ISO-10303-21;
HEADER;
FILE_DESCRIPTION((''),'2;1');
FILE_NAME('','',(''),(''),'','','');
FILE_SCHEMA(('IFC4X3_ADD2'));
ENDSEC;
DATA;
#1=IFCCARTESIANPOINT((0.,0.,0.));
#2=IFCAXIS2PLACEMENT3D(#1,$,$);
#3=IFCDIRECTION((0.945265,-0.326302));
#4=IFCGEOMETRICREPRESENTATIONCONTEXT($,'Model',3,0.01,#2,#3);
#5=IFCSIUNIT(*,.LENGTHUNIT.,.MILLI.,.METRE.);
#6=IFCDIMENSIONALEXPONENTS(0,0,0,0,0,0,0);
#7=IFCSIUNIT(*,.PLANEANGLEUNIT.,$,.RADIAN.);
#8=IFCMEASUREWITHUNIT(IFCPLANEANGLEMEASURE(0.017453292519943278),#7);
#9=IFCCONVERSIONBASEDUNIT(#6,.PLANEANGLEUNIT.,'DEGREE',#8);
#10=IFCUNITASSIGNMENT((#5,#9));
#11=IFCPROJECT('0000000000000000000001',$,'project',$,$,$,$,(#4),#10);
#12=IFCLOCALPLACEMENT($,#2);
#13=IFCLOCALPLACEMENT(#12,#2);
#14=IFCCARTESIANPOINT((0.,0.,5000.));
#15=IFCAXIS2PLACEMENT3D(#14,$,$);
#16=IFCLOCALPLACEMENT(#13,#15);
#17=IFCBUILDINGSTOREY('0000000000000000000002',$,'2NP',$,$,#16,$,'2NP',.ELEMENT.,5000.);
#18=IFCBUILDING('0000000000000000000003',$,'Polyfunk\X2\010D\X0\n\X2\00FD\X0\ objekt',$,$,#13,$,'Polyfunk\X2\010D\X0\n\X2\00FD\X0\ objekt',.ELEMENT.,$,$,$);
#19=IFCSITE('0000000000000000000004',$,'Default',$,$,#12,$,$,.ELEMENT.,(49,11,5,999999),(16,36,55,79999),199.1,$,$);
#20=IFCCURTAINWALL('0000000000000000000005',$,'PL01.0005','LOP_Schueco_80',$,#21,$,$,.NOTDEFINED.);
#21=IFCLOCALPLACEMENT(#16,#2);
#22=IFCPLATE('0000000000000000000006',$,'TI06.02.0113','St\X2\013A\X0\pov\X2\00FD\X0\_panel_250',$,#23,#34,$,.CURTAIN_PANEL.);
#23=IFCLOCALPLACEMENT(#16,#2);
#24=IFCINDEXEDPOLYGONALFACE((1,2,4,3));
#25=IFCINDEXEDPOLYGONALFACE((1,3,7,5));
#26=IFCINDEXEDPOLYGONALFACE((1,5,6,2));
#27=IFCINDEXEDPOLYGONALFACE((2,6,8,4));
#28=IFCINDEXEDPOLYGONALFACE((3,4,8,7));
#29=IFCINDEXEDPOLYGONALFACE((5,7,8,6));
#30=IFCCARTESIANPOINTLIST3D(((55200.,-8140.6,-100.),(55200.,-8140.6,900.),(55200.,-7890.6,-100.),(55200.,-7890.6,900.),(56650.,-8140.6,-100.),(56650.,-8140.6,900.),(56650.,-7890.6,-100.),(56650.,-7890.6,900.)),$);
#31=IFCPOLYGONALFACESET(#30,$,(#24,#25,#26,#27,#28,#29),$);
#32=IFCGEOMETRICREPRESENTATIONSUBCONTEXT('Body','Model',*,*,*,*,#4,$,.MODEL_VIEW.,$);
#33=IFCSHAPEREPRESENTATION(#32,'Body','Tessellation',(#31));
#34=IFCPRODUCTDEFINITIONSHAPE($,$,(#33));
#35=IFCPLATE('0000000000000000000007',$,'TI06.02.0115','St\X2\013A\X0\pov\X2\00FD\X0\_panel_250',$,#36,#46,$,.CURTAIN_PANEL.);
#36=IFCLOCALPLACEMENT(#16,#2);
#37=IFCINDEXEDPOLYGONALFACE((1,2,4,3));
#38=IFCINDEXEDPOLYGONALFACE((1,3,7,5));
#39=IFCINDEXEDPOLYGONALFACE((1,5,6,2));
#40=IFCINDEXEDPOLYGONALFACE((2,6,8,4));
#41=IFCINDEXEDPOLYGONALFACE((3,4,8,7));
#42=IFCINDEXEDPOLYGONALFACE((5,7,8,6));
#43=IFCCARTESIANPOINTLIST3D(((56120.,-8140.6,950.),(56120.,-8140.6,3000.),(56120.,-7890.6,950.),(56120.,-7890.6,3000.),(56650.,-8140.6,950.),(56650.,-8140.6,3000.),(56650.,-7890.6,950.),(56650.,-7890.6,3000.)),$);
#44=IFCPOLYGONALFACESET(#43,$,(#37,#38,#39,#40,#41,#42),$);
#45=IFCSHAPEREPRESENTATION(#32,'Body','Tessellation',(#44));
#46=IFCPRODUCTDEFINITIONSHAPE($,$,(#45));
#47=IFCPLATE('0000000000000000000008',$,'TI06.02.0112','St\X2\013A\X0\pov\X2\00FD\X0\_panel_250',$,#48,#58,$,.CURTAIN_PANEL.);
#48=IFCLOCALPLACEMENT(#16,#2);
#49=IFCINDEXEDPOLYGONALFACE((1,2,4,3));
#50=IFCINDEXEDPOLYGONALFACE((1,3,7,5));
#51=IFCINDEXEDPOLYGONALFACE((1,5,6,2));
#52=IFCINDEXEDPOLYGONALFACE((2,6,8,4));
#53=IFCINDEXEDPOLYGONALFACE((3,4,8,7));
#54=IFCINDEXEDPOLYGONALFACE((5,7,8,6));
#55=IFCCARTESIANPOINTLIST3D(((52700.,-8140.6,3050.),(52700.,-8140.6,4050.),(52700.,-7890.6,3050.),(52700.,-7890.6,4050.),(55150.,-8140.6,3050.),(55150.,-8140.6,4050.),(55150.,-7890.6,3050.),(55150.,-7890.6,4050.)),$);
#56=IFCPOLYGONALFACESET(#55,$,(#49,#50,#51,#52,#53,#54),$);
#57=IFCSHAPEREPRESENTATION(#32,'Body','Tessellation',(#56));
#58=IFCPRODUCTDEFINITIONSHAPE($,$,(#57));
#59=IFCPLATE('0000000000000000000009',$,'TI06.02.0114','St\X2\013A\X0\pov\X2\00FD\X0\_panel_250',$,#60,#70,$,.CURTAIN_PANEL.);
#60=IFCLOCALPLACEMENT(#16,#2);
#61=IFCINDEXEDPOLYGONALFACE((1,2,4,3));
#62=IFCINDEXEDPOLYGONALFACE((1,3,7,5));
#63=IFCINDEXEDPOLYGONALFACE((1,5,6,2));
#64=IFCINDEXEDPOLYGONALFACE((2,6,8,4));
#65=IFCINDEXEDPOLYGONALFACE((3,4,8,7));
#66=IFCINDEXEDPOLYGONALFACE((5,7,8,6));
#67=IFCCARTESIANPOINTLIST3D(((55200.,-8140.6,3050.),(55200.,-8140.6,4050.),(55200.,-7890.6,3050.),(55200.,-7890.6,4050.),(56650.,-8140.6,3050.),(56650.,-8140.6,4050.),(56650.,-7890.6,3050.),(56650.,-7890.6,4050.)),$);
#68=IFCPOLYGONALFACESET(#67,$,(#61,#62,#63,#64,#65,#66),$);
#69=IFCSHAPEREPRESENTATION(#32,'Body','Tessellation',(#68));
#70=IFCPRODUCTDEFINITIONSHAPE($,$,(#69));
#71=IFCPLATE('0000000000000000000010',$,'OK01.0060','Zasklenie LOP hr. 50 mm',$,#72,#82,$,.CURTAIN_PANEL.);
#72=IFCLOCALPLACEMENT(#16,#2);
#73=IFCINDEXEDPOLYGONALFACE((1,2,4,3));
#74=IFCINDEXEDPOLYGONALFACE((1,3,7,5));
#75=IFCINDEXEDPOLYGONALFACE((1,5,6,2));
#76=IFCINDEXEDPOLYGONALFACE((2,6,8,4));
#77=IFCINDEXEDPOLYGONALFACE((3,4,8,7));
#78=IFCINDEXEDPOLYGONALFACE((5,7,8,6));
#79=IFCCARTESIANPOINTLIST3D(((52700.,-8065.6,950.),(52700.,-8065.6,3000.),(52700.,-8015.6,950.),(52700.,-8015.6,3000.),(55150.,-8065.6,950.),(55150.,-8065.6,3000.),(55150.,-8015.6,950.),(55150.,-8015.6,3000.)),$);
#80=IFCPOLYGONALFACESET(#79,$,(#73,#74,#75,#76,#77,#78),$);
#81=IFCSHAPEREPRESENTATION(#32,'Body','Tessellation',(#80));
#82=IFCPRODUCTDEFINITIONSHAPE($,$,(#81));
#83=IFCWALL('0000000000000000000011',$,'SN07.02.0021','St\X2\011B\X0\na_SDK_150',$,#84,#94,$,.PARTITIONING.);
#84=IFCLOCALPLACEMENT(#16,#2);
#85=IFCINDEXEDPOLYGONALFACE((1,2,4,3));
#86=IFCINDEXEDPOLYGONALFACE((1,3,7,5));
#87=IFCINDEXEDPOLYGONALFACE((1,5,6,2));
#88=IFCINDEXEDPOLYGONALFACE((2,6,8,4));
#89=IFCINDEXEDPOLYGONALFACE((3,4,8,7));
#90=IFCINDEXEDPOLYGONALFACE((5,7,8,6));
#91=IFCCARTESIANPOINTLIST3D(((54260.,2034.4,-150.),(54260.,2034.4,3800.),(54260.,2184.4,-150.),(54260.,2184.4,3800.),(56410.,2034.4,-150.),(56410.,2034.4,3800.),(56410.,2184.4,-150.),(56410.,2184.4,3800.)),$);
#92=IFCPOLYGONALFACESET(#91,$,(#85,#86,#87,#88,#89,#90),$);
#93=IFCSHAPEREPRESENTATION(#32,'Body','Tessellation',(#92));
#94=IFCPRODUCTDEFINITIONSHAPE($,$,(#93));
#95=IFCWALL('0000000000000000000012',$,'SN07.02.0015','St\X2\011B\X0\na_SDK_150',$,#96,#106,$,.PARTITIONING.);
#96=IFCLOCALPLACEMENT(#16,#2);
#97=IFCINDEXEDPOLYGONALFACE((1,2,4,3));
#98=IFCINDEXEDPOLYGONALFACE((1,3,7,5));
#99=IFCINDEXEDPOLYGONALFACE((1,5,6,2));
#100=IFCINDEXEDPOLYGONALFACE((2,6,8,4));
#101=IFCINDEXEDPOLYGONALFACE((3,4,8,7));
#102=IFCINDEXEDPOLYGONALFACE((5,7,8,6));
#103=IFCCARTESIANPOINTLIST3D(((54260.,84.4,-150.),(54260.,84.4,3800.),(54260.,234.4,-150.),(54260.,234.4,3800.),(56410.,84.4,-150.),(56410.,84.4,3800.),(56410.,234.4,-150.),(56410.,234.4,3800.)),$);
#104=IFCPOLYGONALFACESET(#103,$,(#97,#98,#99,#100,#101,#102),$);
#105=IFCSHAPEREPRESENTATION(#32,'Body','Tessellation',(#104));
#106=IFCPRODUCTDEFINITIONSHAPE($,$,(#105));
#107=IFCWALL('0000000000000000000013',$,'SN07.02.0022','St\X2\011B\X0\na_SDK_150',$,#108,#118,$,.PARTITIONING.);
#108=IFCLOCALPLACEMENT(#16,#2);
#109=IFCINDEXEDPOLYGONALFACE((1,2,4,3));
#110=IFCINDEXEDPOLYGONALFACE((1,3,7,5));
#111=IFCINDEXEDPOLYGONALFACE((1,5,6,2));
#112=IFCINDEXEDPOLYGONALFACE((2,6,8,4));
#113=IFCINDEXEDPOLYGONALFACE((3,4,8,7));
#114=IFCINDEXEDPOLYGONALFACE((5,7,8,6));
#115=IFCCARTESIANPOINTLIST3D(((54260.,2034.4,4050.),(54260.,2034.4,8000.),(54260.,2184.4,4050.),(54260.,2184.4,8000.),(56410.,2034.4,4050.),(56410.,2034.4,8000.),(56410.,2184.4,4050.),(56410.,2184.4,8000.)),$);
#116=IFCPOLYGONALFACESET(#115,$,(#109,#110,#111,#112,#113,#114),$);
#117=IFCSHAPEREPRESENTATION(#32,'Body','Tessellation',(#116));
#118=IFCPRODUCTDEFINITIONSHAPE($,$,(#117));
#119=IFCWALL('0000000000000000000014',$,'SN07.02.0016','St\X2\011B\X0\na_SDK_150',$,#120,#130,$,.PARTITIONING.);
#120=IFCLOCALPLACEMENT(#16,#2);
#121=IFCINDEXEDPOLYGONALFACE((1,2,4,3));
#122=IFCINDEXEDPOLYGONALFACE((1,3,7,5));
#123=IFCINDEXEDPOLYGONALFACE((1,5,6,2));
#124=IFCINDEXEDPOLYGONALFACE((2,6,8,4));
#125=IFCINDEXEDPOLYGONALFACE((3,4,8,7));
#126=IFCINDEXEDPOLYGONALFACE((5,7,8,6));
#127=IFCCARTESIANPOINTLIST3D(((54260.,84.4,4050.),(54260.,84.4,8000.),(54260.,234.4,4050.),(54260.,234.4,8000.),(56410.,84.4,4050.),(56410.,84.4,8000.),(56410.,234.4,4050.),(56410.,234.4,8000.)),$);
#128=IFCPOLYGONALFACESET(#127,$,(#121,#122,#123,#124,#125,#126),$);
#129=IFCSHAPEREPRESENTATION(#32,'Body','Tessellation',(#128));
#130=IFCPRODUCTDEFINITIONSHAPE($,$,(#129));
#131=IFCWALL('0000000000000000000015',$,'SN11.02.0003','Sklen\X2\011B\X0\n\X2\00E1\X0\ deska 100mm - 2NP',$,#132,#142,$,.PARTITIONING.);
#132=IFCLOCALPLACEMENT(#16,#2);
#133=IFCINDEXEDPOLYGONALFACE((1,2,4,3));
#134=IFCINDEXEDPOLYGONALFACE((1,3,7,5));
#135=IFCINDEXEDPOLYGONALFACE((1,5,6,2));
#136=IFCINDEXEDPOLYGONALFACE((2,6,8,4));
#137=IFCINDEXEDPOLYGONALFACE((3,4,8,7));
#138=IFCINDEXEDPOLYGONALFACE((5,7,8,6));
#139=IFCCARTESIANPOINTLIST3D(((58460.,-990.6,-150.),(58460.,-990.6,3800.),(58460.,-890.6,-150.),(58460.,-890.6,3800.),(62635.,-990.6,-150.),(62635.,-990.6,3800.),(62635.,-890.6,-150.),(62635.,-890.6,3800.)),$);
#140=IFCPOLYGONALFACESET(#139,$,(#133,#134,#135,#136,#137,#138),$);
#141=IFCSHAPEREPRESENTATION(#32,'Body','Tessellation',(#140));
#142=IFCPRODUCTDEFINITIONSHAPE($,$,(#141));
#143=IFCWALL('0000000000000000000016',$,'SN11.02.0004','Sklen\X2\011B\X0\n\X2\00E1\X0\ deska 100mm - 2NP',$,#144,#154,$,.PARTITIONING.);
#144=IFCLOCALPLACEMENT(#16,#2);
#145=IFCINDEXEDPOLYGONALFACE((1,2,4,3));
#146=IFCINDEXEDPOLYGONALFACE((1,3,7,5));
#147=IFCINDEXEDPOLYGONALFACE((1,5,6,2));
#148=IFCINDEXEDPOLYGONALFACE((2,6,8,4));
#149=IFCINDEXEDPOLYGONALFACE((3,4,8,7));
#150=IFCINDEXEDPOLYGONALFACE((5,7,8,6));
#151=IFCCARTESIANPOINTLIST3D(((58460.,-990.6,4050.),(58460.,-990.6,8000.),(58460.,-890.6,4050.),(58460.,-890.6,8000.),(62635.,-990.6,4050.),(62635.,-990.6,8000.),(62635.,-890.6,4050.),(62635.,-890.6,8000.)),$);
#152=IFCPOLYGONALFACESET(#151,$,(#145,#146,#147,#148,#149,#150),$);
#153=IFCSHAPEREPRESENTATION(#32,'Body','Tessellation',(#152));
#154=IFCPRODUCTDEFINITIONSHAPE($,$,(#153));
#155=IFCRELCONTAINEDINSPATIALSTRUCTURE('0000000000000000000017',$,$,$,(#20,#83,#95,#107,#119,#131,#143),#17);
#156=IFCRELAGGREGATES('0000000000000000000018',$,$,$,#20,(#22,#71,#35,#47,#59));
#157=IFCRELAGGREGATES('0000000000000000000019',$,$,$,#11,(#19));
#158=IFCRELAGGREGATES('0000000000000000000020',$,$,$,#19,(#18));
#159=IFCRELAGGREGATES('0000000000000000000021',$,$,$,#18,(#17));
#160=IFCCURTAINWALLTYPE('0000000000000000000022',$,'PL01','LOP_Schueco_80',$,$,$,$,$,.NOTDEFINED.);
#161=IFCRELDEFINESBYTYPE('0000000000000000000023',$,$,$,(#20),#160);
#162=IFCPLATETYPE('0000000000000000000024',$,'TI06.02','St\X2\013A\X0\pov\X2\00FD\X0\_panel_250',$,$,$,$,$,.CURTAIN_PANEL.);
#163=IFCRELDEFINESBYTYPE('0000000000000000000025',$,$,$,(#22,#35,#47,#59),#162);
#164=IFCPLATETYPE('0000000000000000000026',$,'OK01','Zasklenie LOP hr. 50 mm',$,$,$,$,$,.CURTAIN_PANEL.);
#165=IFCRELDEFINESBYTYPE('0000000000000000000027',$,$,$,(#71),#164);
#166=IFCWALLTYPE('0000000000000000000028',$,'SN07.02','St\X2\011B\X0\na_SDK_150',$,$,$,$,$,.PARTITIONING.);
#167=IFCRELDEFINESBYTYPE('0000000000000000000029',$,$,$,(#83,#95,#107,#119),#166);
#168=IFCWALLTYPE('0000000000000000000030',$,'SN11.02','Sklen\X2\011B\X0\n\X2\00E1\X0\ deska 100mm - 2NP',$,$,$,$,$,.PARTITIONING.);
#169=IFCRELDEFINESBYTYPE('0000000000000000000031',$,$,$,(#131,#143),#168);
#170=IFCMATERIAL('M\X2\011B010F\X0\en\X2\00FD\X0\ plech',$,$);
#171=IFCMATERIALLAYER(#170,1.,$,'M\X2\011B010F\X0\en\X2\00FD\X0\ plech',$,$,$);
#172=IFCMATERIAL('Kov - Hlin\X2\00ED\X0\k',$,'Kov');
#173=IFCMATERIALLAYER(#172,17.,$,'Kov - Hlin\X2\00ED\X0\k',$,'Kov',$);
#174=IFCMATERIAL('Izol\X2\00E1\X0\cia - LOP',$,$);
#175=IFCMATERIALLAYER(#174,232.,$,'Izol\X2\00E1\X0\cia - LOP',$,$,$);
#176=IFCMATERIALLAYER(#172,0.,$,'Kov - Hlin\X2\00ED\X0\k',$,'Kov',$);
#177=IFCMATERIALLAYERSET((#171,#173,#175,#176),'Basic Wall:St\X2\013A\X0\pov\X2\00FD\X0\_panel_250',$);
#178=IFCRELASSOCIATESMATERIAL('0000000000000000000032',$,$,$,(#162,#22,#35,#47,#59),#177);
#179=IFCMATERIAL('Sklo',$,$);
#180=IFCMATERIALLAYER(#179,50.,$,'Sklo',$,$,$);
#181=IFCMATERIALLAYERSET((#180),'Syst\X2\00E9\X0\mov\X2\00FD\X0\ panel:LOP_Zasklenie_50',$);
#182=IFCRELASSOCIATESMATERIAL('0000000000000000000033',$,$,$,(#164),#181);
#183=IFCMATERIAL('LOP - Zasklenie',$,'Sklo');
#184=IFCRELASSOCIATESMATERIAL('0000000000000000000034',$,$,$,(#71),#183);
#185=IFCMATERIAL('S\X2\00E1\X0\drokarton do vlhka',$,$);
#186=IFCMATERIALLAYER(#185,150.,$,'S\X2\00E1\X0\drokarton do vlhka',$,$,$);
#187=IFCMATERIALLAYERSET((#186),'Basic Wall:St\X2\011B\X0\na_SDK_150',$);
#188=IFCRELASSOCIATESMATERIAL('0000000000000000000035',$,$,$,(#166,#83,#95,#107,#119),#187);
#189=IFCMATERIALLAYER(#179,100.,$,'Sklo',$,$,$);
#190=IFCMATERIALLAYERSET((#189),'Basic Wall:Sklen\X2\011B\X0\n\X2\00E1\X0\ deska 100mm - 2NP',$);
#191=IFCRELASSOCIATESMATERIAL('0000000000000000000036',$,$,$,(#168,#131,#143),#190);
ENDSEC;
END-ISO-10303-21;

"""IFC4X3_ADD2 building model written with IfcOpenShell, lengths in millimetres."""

from ifc_helpers import new_model, entity, si_unit, converted_unit, direction, frame, frame_2d, origin, origin_2d_with_axis, place, context, subcontext, project, spatial, polyline, rectangle, extrude, clip, bounded_halfspace, source, transform, mapped, material, layer, layer_set, layer_usage, type_object, type_shapes, element, aggregate, save


model = new_model("IFC4X3_ADD2")

# Units and contexts
model_context = context("Model", 3, precision=0.01, world=origin(), true_north=direction((0.945265, -0.326302)))
body_context = subcontext(model_context, "Body", "Model", "MODEL_VIEW")
ifc_project = project(units=[si_unit("LENGTHUNIT", "METRE", prefix="MILLI"), converted_unit("PLANEANGLEUNIT", "DEGREE", entity("IfcPlaneAngleMeasure", 0.017453292519943278), si_unit("PLANEANGLEUNIT", "RADIAN"), dimensions=[0, 0, 0, 0, 0, 0, 0])], contexts=[model_context])

# Site, building, storey
site_placement = place(None, origin())
site = spatial("IfcSite", under=ifc_project, at=site_placement, Name="Default", CompositionType="ELEMENT", RefLatitude=(49, 11, 5, 999999), RefLongitude=(16, 36, 55, 79999), RefElevation=199.1)
building_placement = place(site_placement, origin())
building = spatial("IfcBuilding", under=site, at=building_placement, Name="Polyfunkčný objekt", LongName="Polyfunkčný objekt", CompositionType="ELEMENT")
storey_placement = place(building_placement, frame((0.0, 0.0, 5000.0)))
storey = spatial("IfcBuildingStorey", under=building, at=storey_placement, Name="2NP", LongName="2NP", CompositionType="ELEMENT", Elevation=5000.0)

# Curtain wall, plates
curtain_wall_type = type_object("IfcCurtainWallType", Name="PL01", Description="LOP_Schueco_80", PredefinedType="NOTDEFINED")
curtain_wall_placement = place(storey_placement, frame((0.0, 0.0, -5000.0)))
curtain_wall = element("IfcCurtainWall", 1, at=curtain_wall_placement, inside=storey, type_object=curtain_wall_type, Name="PL01.0005", Description="LOP_Schueco_80", PredefinedType="NOTDEFINED")
ifc_material_1 = material(Name="Měďený plech")
ifc_layer_1 = layer(ifc_material_1, 1.0, Name="Měďený plech")
ifc_material_2 = material(Name="Kov - Hliník", Category="Kov")
ifc_layer_2 = layer(ifc_material_2, 17.0, Name="Kov - Hliník", Category="Kov")
ifc_material_3 = material(Name="Izolácia - LOP")
ifc_layer_3 = layer(ifc_material_3, 232.0, Name="Izolácia - LOP")
ifc_layer_4 = layer(ifc_material_2, 0.0, Name="Kov - Hliník", Category="Kov")
ifc_layer_set_1 = layer_set([ifc_layer_1, ifc_layer_2, ifc_layer_3, ifc_layer_4], Name="Basic Wall:Stĺpový_panel_250")
ifc_layer_usage_1 = layer_usage(ifc_layer_set_1, "AXIS2", "POSITIVE", -125.0)
plate_type_1 = type_object("IfcPlateType", Name="TI06.02", Description="Stĺpový_panel_250", PredefinedType="CURTAIN_PANEL", material=ifc_layer_set_1)
plate_1_placement = place(storey_placement, frame((55200.0, -8015.6, -100.0)))
plate_1 = element("IfcPlate", 2, at=plate_1_placement, type_object=plate_type_1, material=ifc_layer_usage_1, Name="TI06.02.0113", Description="Stĺpový_panel_250", PredefinedType="CURTAIN_PANEL", context=body_context, shape_type="SweptSolid", body=[
    extrude(rectangle(XDim=250.0, YDim=1450.0, at=frame_2d((0.0, 0.0), x_axis=(1.0, 0.0))), frame((725.0, 0.0, 0.0), z_axis=(0.0, 0.0, 1.0), x_axis=(0.0, 1.0, 0.0)), (0.0, 0.0, 1.0), 1000.0),
])
ifc_layer_usage_2 = layer_usage(ifc_layer_set_1, "AXIS2", "POSITIVE", -125.0)
plate_2_placement = place(storey_placement, frame((56120.0, -8015.6, 950.0)))
plate_2 = element("IfcPlate", 3, at=plate_2_placement, type_object=plate_type_1, material=ifc_layer_usage_2, Name="TI06.02.0115", Description="Stĺpový_panel_250", PredefinedType="CURTAIN_PANEL", context=body_context, shape_type="SweptSolid", body=[
    extrude(rectangle(XDim=250.0, YDim=530.0, at=origin_2d_with_axis()), frame((265.0, 0.0, 0.0), z_axis=(0.0, 0.0, 1.0), x_axis=(0.0, 1.0, 0.0)), (0.0, 0.0, 1.0), 2050.0),
])
ifc_layer_usage_3 = layer_usage(ifc_layer_set_1, "AXIS2", "POSITIVE", -125.0)
plate_3_placement = place(storey_placement, frame((52700.0, -8015.6, 3050.0)))
plate_3 = element("IfcPlate", 4, at=plate_3_placement, type_object=plate_type_1, material=ifc_layer_usage_3, Name="TI06.02.0112", Description="Stĺpový_panel_250", PredefinedType="CURTAIN_PANEL", context=body_context, shape_type="SweptSolid", body=[
    extrude(rectangle(XDim=250.0, YDim=2450.0, at=frame_2d((0.0, 0.0), x_axis=(1.0, 0.0))), frame((1225.0, 0.0, 0.0), z_axis=(0.0, 0.0, 1.0), x_axis=(0.0, 1.0, 0.0)), (0.0, 0.0, 1.0), 1000.0),
])
ifc_layer_usage_4 = layer_usage(ifc_layer_set_1, "AXIS2", "POSITIVE", -125.0)
plate_4_placement = place(storey_placement, frame((55200.0, -8015.6, 3050.0)))
plate_4 = element("IfcPlate", 5, at=plate_4_placement, type_object=plate_type_1, material=ifc_layer_usage_4, Name="TI06.02.0114", Description="Stĺpový_panel_250", PredefinedType="CURTAIN_PANEL", context=body_context, shape_type="SweptSolid", body=[
    extrude(rectangle(XDim=250.0, YDim=1450.0, at=frame_2d((0.0, 0.0), x_axis=(1.0, 0.0))), frame((725.0, 0.0, 0.0), z_axis=(0.0, 0.0, 1.0), x_axis=(0.0, 1.0, 0.0)), (0.0, 0.0, 1.0), 1000.0),
])
ifc_material_4 = material(Name="LOP - Zasklenie", Category="Sklo")
ifc_material_5 = material(Name="Sklo")
ifc_layer_5 = layer(ifc_material_5, 50.0, Name="Sklo")
ifc_layer_set_2 = layer_set([ifc_layer_5], Name="Systémový panel:LOP_Zasklenie_50")
plate_type_2 = type_object("IfcPlateType", Name="OK01", Description="Zasklenie LOP hr. 50 mm", PredefinedType="CURTAIN_PANEL", material=ifc_layer_set_2)
shared_shape_1 = source(origin(), body_context, "Body", "SweptSolid", [
    extrude(rectangle(XDim=50.0, YDim=2450.0, at=origin_2d_with_axis()), frame((0.0, -25.0, 0.0), z_axis=(0.0, 0.0, 1.0), x_axis=(0.0, 1.0, 0.0)), (0.0, 0.0, 1.0), 2050.0),
])
type_shapes(plate_type_2, [shared_shape_1])
plate_5_placement = place(curtain_wall_placement, frame((53925.0, -8015.6, 5950.0)))
plate_5 = element("IfcPlate", 6, at=plate_5_placement, type_object=plate_type_2, material=ifc_material_4, Name="OK01.0060", Description="Zasklenie LOP hr. 50 mm", PredefinedType="CURTAIN_PANEL", context=body_context, shape_type="MappedRepresentation", body=[
    mapped(shared_shape_1, transform((0.0, 0.0, 0.0), scale=1.0)),
])

# Walls
ifc_material_6 = material(Name="Sádrokarton do vlhka")
ifc_layer_6 = layer(ifc_material_6, 150.0, Name="Sádrokarton do vlhka")
ifc_layer_set_3 = layer_set([ifc_layer_6], Name="Basic Wall:Stěna_SDK_150")
wall_type_1 = type_object("IfcWallType", Name="SN07.02", Description="Stěna_SDK_150", PredefinedType="PARTITIONING", material=ifc_layer_set_3)
wall_1_placement = place(storey_placement, frame((56410.0, 2109.4, -150.0), z_axis=(0.0, 0.0, 1.0), x_axis=(-1.0, 0.0, 0.0)))
element("IfcWall", 7, at=wall_1_placement, inside=storey, type_object=wall_type_1, material=ifc_layer_set_3, Name="SN07.02.0021", Description="Stěna_SDK_150", PredefinedType="PARTITIONING", context=body_context, shape_type="Clipping", body=[
    clip(clip(extrude(rectangle(XDim=2150.0, YDim=150.0, at=frame_2d((1075.0, 0.0), x_axis=(-1.0, 0.0))), origin(), (0.0, 0.0, 1.0), 3950.0), bounded_halfspace(frame((2150.0, -75.0, 0.0)), True, frame((2150.0, -75.0, 0.0)), polyline([(0.0, 0.0), (0.0, 150.0), (-2150.0, 150.0), (-2150.0, 0.0), (0.0, 0.0)]))), bounded_halfspace(frame((0.0, -75.0, 3950.0), z_axis=(0.0, 0.0, -1.0), x_axis=(-1.0, 0.0, 0.0)), True, frame((0.0, -75.0, 3950.0)), polyline([(0.0, 0.0), (2150.0, 0.0), (2150.0, 150.0), (0.0, 150.0), (0.0, 0.0)]))),
])
wall_2_placement = place(storey_placement, frame((56410.0, 159.4, -150.0), z_axis=(0.0, 0.0, 1.0), x_axis=(-1.0, 0.0, 0.0)))
element("IfcWall", 8, at=wall_2_placement, inside=storey, type_object=wall_type_1, material=ifc_layer_set_3, Name="SN07.02.0015", Description="Stěna_SDK_150", PredefinedType="PARTITIONING", context=body_context, shape_type="Clipping", body=[
    clip(clip(extrude(rectangle(XDim=2150.0, YDim=150.0, at=frame_2d((1075.0, 0.0), x_axis=(-1.0, 0.0))), origin(), (0.0, 0.0, 1.0), 3950.0), bounded_halfspace(frame((2150.0, -75.0, 0.0)), True, frame((2150.0, -75.0, 0.0)), polyline([(0.0, 0.0), (0.0, 150.0), (-2150.0, 150.0), (-2150.0, 0.0), (0.0, 0.0)]))), bounded_halfspace(frame((0.0, -75.0, 3950.0), z_axis=(0.0, 0.0, -1.0), x_axis=(-1.0, 0.0, 0.0)), True, frame((0.0, -75.0, 3950.0)), polyline([(0.0, 0.0), (2150.0, 0.0), (2150.0, 150.0), (0.0, 150.0), (0.0, 0.0)]))),
])
wall_3_placement = place(storey_placement, frame((56410.0, 2109.4, 4050.0), z_axis=(0.0, 0.0, 1.0), x_axis=(-1.0, 0.0, 0.0)))
element("IfcWall", 9, at=wall_3_placement, inside=storey, type_object=wall_type_1, material=ifc_layer_set_3, Name="SN07.02.0022", Description="Stěna_SDK_150", PredefinedType="PARTITIONING", context=body_context, shape_type="Clipping", body=[
    clip(clip(extrude(rectangle(XDim=2150.0, YDim=150.0, at=frame_2d((1075.0, 0.0), x_axis=(-1.0, 0.0))), origin(), (0.0, 0.0, 1.0), 3950.0), bounded_halfspace(frame((2150.0, -75.0, 0.0)), True, frame((2150.0, -75.0, 0.0)), polyline([(0.0, 0.0), (0.0, 150.0), (-2150.0, 150.0), (-2150.0, 0.0), (0.0, 0.0)]))), bounded_halfspace(frame((0.0, -75.0, 3950.0), z_axis=(0.0, 0.0, -1.0), x_axis=(-1.0, 0.0, 0.0)), True, frame((0.0, -75.0, 3950.0)), polyline([(0.0, 0.0), (2150.0, 0.0), (2150.0, 150.0), (0.0, 150.0), (0.0, 0.0)]))),
])
wall_4_placement = place(storey_placement, frame((56410.0, 159.4, 4050.0), z_axis=(0.0, 0.0, 1.0), x_axis=(-1.0, 0.0, 0.0)))
element("IfcWall", 10, at=wall_4_placement, inside=storey, type_object=wall_type_1, material=ifc_layer_set_3, Name="SN07.02.0016", Description="Stěna_SDK_150", PredefinedType="PARTITIONING", context=body_context, shape_type="Clipping", body=[
    clip(clip(extrude(rectangle(XDim=2150.0, YDim=150.0, at=frame_2d((1075.0, 0.0), x_axis=(-1.0, 0.0))), origin(), (0.0, 0.0, 1.0), 3950.0), bounded_halfspace(frame((2150.0, -75.0, 0.0)), True, frame((2150.0, -75.0, 0.0)), polyline([(0.0, 0.0), (0.0, 150.0), (-2150.0, 150.0), (-2150.0, 0.0), (0.0, 0.0)]))), bounded_halfspace(frame((0.0, -75.0, 3950.0), z_axis=(0.0, 0.0, -1.0), x_axis=(-1.0, 0.0, 0.0)), True, frame((0.0, -75.0, 3950.0)), polyline([(0.0, 0.0), (2150.0, 0.0), (2150.0, 150.0), (0.0, 150.0), (0.0, 0.0)]))),
])
ifc_layer_7 = layer(ifc_material_5, 100.0, Name="Sklo")
ifc_layer_set_4 = layer_set([ifc_layer_7], Name="Basic Wall:Skleněná deska 100mm - 2NP")
wall_type_2 = type_object("IfcWallType", Name="SN11.02", Description="Skleněná deska 100mm - 2NP", PredefinedType="PARTITIONING", material=ifc_layer_set_4)
wall_5_placement = place(storey_placement, frame((58460.0, -940.6, -150.0)))
element("IfcWall", 11, at=wall_5_placement, inside=storey, type_object=wall_type_2, material=ifc_layer_set_4, Name="SN11.02.0003", Description="Skleněná deska 100mm - 2NP", PredefinedType="PARTITIONING", context=body_context, shape_type="Clipping", body=[
    clip(clip(extrude(rectangle(XDim=4175.0, YDim=100.0, at=frame_2d((2087.5, 0.0), x_axis=(-1.0, 0.0))), origin(), (0.0, 0.0, 1.0), 3950.0), bounded_halfspace(frame((4175.0, -50.0, 0.0), z_axis=(0.0, 0.0, 1.0), x_axis=(-1.0, 0.0, 0.0)), True, frame((4175.0, -50.0, 0.0)), polyline([(0.0, 0.0), (0.0, 100.0), (-4075.0, 100.0), (-4175.0, 100.0), (-4175.0, 0.0), (0.0, 0.0)]))), bounded_halfspace(frame((0.0, -50.0, 3950.0), z_axis=(0.0, 0.0, -1.0), x_axis=(1.0, 0.0, 0.0)), True, frame((0.0, -50.0, 3950.0)), polyline([(0.0, 0.0), (4175.0, 0.0), (4175.0, 100.0), (100.0, 100.0), (0.0, 100.0), (0.0, 0.0)]))),
])
wall_6_placement = place(storey_placement, frame((58460.0, -940.6, 4050.0)))
element("IfcWall", 12, at=wall_6_placement, inside=storey, type_object=wall_type_2, material=ifc_layer_set_4, Name="SN11.02.0004", Description="Skleněná deska 100mm - 2NP", PredefinedType="PARTITIONING", context=body_context, shape_type="Clipping", body=[
    clip(clip(extrude(rectangle(XDim=4175.0, YDim=100.0, at=frame_2d((2087.5, 0.0), x_axis=(-1.0, 0.0))), origin(), (0.0, 0.0, 1.0), 3950.0), bounded_halfspace(frame((4175.0, -50.0, 0.0), z_axis=(0.0, 0.0, 1.0), x_axis=(-1.0, 0.0, 0.0)), True, frame((4175.0, -50.0, 0.0)), polyline([(0.0, 0.0), (0.0, 100.0), (-4075.0, 100.0), (-4175.0, 100.0), (-4175.0, 0.0), (0.0, 0.0)]))), bounded_halfspace(frame((0.0, -50.0, 3950.0), z_axis=(0.0, 0.0, -1.0), x_axis=(1.0, 0.0, 0.0)), True, frame((0.0, -50.0, 3950.0)), polyline([(0.0, 0.0), (4175.0, 0.0), (4175.0, 100.0), (100.0, 100.0), (0.0, 100.0), (0.0, 0.0)]))),
])

aggregate(curtain_wall, [plate_1, plate_5, plate_2, plate_3, plate_4])

save(model, "model.ifc")
